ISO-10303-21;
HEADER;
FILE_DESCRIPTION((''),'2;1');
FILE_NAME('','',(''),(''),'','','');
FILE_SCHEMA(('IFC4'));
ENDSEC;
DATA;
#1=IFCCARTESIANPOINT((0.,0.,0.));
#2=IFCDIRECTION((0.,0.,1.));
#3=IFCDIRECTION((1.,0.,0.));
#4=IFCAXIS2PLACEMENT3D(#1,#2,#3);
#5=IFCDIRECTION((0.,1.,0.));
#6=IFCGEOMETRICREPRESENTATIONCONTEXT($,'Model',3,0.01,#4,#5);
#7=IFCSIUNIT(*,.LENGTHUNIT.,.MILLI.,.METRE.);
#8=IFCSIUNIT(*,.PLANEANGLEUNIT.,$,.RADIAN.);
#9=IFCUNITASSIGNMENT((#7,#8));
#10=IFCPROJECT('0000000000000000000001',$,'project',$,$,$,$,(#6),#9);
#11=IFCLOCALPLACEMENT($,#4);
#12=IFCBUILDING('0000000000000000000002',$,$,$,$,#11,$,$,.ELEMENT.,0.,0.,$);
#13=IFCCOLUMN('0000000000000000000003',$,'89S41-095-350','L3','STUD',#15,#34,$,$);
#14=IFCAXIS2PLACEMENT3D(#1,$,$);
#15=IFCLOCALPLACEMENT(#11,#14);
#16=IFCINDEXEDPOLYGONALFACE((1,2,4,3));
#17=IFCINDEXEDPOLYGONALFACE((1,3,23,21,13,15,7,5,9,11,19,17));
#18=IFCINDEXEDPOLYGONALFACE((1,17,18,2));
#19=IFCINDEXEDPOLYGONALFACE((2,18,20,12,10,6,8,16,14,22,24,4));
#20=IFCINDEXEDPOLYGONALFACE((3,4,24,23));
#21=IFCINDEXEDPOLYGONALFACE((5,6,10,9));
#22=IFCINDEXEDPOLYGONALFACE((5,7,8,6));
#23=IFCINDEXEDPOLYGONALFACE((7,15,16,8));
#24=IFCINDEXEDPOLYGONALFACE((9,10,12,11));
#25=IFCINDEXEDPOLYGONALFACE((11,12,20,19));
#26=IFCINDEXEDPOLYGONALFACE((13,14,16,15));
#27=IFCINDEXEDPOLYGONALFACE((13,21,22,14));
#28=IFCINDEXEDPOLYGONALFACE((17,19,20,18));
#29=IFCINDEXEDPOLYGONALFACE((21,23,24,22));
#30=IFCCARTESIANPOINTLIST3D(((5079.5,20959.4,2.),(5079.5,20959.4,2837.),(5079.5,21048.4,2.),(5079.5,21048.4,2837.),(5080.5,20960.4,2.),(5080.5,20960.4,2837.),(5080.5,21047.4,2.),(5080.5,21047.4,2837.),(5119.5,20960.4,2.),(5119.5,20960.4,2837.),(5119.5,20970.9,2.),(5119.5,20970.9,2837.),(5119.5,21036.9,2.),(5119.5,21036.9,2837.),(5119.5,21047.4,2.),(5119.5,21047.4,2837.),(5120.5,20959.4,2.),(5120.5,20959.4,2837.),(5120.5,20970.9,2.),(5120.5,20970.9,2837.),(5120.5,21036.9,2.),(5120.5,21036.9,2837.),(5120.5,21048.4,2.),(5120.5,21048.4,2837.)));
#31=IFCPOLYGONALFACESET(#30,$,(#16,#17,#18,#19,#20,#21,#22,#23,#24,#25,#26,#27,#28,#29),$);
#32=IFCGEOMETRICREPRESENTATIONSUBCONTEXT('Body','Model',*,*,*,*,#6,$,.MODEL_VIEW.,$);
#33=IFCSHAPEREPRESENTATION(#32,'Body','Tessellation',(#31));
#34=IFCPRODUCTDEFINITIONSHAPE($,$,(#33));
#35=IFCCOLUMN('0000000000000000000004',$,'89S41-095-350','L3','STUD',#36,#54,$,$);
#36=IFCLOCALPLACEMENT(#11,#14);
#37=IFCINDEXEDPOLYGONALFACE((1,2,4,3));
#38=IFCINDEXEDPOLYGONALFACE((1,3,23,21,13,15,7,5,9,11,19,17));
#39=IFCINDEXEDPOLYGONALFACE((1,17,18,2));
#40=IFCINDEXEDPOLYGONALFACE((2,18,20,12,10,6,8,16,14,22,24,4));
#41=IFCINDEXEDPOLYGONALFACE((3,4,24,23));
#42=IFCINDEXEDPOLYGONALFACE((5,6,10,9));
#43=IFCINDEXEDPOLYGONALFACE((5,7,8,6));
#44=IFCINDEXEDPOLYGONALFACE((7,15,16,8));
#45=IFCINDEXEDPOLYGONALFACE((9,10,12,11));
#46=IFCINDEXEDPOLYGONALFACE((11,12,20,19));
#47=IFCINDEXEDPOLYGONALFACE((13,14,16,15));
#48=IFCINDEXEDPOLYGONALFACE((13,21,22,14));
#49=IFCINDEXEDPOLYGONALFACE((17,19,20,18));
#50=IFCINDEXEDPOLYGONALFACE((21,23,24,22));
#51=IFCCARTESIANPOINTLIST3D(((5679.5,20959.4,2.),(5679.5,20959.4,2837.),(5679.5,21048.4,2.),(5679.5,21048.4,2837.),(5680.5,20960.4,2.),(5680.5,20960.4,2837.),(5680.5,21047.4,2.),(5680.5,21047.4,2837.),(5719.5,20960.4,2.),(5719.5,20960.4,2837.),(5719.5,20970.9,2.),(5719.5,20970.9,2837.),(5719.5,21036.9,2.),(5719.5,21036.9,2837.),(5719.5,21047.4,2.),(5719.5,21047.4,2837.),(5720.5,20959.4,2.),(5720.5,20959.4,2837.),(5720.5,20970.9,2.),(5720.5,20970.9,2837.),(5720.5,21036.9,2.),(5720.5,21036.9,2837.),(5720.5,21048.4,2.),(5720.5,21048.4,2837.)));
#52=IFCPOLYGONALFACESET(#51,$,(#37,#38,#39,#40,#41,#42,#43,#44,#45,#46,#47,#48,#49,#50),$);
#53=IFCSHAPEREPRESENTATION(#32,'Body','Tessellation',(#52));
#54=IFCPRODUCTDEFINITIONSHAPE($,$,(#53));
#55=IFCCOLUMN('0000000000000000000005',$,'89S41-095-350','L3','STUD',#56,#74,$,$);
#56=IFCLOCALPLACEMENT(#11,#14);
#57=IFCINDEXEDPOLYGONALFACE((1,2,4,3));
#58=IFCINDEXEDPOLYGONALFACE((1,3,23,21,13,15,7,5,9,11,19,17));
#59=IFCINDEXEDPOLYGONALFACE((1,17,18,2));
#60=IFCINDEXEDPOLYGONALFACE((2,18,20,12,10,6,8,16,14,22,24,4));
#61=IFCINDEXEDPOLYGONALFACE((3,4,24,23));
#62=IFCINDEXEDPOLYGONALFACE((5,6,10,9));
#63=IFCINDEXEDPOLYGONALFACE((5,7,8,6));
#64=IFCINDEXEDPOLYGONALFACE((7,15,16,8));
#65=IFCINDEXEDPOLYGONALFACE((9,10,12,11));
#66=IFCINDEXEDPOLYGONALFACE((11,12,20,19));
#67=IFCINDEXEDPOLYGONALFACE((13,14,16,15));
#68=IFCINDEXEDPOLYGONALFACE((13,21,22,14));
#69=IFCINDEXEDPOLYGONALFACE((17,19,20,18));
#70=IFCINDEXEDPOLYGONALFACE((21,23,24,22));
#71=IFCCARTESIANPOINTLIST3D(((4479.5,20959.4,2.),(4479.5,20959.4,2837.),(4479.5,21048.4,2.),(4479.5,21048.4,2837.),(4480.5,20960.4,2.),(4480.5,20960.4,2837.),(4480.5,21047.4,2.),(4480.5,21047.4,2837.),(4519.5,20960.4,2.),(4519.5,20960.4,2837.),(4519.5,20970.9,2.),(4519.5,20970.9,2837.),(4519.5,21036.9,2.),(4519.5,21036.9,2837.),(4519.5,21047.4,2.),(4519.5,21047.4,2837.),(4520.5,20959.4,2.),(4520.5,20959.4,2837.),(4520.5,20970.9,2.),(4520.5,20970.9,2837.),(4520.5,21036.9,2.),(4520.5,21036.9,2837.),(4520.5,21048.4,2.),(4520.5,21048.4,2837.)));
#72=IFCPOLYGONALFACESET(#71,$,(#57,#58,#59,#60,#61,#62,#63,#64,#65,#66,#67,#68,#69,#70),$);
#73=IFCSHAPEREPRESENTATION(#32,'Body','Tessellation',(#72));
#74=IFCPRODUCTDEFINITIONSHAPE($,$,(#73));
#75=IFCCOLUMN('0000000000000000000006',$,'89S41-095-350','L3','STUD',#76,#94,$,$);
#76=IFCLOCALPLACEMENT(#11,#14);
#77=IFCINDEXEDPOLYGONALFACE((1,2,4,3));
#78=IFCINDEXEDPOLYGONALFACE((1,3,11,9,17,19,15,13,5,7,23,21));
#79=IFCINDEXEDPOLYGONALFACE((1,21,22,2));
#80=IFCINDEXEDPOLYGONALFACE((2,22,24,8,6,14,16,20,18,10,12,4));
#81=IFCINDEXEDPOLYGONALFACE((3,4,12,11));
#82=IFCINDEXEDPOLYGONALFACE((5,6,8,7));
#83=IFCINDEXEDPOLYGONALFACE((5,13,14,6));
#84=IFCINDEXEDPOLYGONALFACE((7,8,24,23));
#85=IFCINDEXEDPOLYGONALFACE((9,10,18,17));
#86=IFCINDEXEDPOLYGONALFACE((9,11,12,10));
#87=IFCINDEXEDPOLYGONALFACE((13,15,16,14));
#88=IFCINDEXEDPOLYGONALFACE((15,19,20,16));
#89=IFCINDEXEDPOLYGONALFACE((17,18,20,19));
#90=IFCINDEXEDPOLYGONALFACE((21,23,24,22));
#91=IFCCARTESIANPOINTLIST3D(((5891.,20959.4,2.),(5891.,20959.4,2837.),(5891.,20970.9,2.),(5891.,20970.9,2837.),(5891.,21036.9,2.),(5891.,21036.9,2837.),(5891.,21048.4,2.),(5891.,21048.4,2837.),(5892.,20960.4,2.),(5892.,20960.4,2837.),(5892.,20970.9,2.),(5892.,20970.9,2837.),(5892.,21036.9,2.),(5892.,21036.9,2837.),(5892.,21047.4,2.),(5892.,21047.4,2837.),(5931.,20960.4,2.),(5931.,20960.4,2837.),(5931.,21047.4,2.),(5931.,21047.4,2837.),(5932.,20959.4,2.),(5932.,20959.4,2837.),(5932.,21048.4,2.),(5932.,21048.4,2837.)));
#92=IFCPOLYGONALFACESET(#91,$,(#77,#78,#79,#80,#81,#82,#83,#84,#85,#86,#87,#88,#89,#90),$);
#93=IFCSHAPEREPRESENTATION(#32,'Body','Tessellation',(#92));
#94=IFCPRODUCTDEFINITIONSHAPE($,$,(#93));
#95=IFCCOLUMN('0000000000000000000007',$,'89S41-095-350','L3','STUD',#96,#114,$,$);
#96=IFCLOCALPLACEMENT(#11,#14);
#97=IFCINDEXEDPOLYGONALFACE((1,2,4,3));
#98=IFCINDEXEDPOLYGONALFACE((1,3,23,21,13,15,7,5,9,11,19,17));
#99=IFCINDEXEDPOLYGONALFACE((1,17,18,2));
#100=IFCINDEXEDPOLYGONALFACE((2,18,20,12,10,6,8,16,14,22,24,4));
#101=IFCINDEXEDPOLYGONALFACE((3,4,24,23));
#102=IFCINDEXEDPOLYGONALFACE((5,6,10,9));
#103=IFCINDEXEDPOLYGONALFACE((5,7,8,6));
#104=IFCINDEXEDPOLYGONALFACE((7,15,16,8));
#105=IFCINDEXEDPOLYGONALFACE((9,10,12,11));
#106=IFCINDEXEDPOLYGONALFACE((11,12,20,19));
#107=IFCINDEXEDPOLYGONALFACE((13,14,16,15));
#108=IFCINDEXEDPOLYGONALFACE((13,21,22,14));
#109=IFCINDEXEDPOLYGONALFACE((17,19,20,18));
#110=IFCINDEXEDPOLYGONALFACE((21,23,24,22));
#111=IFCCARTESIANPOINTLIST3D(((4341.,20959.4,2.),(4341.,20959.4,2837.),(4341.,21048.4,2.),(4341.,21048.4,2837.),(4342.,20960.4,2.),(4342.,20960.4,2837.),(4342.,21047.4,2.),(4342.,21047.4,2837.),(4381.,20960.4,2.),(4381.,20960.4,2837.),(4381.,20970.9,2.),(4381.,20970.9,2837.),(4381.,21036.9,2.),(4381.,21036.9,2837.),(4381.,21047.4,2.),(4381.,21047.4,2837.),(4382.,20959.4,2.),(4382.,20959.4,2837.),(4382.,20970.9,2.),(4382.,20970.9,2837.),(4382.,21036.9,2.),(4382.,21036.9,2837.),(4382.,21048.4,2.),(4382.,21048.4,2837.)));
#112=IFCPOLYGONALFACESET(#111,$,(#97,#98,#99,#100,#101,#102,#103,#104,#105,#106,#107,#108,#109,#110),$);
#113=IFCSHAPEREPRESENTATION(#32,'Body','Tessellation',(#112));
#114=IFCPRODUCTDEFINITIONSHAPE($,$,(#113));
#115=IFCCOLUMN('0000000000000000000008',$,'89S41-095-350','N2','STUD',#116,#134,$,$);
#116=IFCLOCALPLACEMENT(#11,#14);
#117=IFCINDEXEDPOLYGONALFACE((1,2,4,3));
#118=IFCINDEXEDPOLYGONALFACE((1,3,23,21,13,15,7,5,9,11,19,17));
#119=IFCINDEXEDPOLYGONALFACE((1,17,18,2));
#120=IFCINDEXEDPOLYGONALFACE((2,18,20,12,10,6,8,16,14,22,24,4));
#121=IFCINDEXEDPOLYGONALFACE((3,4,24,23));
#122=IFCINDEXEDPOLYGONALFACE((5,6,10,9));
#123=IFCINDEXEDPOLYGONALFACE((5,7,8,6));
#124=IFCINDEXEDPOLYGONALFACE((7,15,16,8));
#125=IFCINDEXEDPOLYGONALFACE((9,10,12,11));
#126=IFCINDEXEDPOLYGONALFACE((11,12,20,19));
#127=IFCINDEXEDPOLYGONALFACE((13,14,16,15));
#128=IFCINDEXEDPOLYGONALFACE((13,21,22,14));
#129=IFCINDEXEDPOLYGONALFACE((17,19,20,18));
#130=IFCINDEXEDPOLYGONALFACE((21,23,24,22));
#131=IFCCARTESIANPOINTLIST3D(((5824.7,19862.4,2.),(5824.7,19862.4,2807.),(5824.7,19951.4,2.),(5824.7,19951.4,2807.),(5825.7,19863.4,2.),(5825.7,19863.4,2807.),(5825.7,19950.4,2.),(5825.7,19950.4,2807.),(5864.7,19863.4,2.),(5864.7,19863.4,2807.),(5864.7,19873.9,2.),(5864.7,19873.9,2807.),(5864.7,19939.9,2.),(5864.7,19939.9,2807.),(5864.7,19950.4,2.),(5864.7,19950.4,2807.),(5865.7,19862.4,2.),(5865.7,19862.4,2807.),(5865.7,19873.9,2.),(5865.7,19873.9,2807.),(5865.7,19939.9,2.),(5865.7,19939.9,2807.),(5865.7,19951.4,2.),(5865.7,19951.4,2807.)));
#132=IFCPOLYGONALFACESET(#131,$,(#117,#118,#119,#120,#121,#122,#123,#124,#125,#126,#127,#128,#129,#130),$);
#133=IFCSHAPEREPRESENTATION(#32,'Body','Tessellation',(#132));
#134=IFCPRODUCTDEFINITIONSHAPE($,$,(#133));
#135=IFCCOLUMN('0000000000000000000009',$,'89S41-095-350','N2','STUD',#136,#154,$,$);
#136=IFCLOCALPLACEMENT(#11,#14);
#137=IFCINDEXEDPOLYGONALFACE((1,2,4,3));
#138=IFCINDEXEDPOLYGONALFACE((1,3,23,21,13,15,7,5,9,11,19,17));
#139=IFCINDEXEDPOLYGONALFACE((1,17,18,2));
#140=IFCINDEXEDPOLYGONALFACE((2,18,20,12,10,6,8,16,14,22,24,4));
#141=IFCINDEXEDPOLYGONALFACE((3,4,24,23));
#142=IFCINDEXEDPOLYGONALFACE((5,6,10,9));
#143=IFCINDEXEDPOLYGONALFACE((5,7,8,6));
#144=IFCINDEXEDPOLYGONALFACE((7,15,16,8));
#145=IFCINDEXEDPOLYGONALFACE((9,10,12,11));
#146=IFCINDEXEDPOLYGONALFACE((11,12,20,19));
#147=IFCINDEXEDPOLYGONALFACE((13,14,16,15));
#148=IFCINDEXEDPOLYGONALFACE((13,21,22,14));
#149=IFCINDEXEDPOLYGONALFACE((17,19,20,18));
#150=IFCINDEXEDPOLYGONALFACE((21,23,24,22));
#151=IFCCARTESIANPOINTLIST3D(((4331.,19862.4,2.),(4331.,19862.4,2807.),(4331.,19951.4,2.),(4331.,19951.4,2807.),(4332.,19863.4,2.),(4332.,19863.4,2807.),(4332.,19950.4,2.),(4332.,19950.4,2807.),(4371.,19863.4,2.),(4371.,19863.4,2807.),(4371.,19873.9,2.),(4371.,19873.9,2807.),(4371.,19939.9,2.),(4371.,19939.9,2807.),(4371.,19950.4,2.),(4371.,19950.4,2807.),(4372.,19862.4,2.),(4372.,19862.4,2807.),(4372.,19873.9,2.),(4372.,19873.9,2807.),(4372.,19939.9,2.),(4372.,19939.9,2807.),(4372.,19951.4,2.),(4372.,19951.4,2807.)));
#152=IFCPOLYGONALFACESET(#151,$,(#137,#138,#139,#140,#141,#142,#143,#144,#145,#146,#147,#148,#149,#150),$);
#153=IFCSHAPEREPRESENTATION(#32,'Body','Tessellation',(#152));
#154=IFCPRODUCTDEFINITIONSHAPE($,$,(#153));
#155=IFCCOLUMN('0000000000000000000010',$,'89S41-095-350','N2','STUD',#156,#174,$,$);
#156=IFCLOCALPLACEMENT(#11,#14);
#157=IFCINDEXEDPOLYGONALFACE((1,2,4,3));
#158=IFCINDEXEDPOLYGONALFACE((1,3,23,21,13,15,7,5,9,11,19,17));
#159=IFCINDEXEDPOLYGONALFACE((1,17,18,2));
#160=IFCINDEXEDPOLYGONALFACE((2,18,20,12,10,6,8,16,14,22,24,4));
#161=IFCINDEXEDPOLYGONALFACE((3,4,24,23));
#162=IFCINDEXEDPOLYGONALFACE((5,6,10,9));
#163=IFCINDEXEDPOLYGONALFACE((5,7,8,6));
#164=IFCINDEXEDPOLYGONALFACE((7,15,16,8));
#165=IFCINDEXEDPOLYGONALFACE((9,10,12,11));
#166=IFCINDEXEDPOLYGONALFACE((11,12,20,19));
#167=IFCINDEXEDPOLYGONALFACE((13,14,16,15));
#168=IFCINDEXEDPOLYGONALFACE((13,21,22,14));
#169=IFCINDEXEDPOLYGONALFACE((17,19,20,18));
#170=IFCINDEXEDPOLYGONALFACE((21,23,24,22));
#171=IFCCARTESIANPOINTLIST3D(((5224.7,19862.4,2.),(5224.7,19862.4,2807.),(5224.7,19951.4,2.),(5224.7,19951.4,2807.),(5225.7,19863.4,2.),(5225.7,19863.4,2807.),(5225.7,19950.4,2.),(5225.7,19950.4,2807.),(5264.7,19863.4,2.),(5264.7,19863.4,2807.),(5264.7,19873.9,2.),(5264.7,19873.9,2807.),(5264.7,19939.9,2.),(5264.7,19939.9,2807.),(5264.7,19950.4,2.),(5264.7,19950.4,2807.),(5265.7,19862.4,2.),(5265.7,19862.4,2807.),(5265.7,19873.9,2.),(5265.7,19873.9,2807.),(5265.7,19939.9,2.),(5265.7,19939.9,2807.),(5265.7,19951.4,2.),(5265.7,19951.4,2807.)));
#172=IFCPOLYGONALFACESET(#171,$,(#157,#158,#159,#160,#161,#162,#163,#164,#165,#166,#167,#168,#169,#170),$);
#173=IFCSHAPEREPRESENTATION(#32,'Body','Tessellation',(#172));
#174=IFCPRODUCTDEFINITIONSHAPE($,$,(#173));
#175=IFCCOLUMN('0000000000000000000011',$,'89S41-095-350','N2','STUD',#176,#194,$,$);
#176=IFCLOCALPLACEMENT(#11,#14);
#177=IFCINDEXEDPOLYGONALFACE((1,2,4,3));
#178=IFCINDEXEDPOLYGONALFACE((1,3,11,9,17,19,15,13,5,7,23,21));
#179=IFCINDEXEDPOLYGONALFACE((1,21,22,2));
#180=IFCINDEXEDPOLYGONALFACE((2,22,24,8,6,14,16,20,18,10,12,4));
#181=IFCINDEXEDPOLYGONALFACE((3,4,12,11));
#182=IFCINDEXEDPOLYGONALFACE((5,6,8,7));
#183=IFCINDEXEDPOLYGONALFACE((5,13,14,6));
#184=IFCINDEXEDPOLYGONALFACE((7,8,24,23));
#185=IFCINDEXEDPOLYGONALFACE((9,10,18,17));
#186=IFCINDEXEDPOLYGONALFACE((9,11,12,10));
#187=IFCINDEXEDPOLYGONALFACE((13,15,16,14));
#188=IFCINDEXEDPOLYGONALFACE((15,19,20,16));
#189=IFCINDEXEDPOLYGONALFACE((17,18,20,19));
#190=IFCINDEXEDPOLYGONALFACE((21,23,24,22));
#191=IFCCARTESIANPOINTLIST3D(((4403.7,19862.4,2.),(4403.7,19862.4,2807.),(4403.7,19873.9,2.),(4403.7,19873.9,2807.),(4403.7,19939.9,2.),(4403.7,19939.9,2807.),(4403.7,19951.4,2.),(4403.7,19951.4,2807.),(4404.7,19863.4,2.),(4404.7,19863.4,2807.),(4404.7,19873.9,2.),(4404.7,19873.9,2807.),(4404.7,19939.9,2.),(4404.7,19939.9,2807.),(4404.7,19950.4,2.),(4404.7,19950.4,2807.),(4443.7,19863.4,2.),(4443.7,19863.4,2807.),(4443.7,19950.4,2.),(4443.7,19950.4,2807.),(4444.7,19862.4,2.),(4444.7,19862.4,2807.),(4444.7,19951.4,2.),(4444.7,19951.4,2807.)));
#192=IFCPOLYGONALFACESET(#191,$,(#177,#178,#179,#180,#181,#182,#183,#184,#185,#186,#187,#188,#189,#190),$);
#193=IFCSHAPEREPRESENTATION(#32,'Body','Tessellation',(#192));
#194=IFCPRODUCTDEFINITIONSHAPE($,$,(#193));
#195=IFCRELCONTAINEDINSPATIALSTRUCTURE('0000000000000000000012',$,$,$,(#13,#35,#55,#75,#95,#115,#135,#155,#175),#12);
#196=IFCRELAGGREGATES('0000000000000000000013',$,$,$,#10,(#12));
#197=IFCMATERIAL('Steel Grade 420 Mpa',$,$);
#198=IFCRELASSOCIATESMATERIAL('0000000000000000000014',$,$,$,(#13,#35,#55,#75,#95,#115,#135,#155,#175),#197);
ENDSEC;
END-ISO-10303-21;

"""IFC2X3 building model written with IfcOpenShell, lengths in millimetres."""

from ifc_helpers import new_model, si_unit, direction, frame, origin, origin_with_axes, origin_2d_with_axis, place, context, subcontext, project, spatial, c_section, extrude, source, transform, mapped, material, element, save


model = new_model("IFC2X3")

# Units and contexts
model_context = context("Model", 3, precision=0.01, world=origin_with_axes(), true_north=direction((0.0, 1.0, 0.0)))
body_context = subcontext(model_context, "Body", "Model", "MODEL_VIEW")
ifc_project = project(units=[si_unit("LENGTHUNIT", "METRE", prefix="MILLI"), si_unit("PLANEANGLEUNIT", "RADIAN")], contexts=[model_context])

# Building
building_placement = place(None, origin_with_axes())
building = spatial("IfcBuilding", under=ifc_project, at=building_placement, CompositionType="ELEMENT", ElevationOfRefHeight=0.0, ElevationOfTerrain=0.0)

# Columns
ifc_material = material(Name="Steel Grade 420 Mpa")
shared_shape_1 = source(origin(), body_context, "Body", "SweptSolid", [
    extrude(c_section(Depth=89.0, Width=41.0, WallThickness=1.0, Girth=11.5, at=origin_2d_with_axis()), origin_with_axes(), (0.0, 0.0, 1.0), 2835.0),
])
column_1_placement = place(None, frame((5100.0, 21003.9, 2.0), z_axis=(0.0, 0.0, 1.0), x_axis=(1.0, 0.0, 0.0)))
element("IfcColumn", 1, at=column_1_placement, inside=building, material=ifc_material, Name="89S41-095-350", Description="L3", ObjectType="STUD", context=body_context, shape_type="MappedRepresentation", body=[
    mapped(shared_shape_1, transform((0.0, 0.0, 0.0), scale=1.0)),
])
shared_shape_2 = source(origin(), body_context, "Body", "SweptSolid", [
    extrude(c_section(Depth=89.0, Width=41.0, WallThickness=1.0, Girth=11.5, at=origin_2d_with_axis()), origin_with_axes(), (0.0, 0.0, 1.0), 2835.0),
])
column_2_placement = place(None, frame((5700.0, 21003.9, 2.0), z_axis=(0.0, 0.0, 1.0), x_axis=(1.0, 0.0, 0.0)))
element("IfcColumn", 2, at=column_2_placement, inside=building, material=ifc_material, Name="89S41-095-350", Description="L3", ObjectType="STUD", context=body_context, shape_type="MappedRepresentation", body=[
    mapped(shared_shape_2, transform((0.0, 0.0, 0.0), scale=1.0)),
])
shared_shape_3 = source(origin(), body_context, "Body", "SweptSolid", [
    extrude(c_section(Depth=89.0, Width=41.0, WallThickness=1.0, Girth=11.5, at=origin_2d_with_axis()), origin_with_axes(), (0.0, 0.0, 1.0), 2835.0),
])
column_3_placement = place(None, frame((4500.0, 21003.9, 2.0), z_axis=(0.0, 0.0, 1.0), x_axis=(1.0, 0.0, 0.0)))
element("IfcColumn", 3, at=column_3_placement, inside=building, material=ifc_material, Name="89S41-095-350", Description="L3", ObjectType="STUD", context=body_context, shape_type="MappedRepresentation", body=[
    mapped(shared_shape_3, transform((0.0, 0.0, 0.0), scale=1.0)),
])
shared_shape_4 = source(origin(), body_context, "Body", "SweptSolid", [
    extrude(c_section(Depth=89.0, Width=41.0, WallThickness=1.0, Girth=11.5, at=origin_2d_with_axis()), origin_with_axes(), (0.0, 0.0, 1.0), 2835.0),
])
column_4_placement = place(None, frame((5911.5, 21003.9, 2.0), z_axis=(0.0, 0.0, 1.0), x_axis=(-1.0, 0.0, 0.0)))
element("IfcColumn", 4, at=column_4_placement, inside=building, material=ifc_material, Name="89S41-095-350", Description="L3", ObjectType="STUD", context=body_context, shape_type="MappedRepresentation", body=[
    mapped(shared_shape_4, transform((0.0, 0.0, 0.0), scale=1.0)),
])
shared_shape_5 = source(origin(), body_context, "Body", "SweptSolid", [
    extrude(c_section(Depth=89.0, Width=41.0, WallThickness=1.0, Girth=11.5, at=origin_2d_with_axis()), origin_with_axes(), (0.0, 0.0, 1.0), 2835.0),
])
column_5_placement = place(None, frame((4361.5, 21003.9, 2.0), z_axis=(0.0, 0.0, 1.0), x_axis=(1.0, 0.0, 0.0)))
element("IfcColumn", 5, at=column_5_placement, inside=building, material=ifc_material, Name="89S41-095-350", Description="L3", ObjectType="STUD", context=body_context, shape_type="MappedRepresentation", body=[
    mapped(shared_shape_5, transform((0.0, 0.0, 0.0), scale=1.0)),
])
shared_shape_6 = source(origin(), body_context, "Body", "SweptSolid", [
    extrude(c_section(Depth=89.0, Width=41.0, WallThickness=1.0, Girth=11.5, at=origin_2d_with_axis()), origin_with_axes(), (0.0, 0.0, 1.0), 2805.0),
])
column_6_placement = place(None, frame((5845.2, 19906.9, 2.0), z_axis=(0.0, 0.0, 1.0), x_axis=(1.0, 0.0, 0.0)))
element("IfcColumn", 6, at=column_6_placement, inside=building, material=ifc_material, Name="89S41-095-350", Description="N2", ObjectType="STUD", context=body_context, shape_type="MappedRepresentation", body=[
    mapped(shared_shape_6, transform((0.0, 0.0, 0.0), scale=1.0)),
])
shared_shape_7 = source(origin(), body_context, "Body", "SweptSolid", [
    extrude(c_section(Depth=89.0, Width=41.0, WallThickness=1.0, Girth=11.5, at=origin_2d_with_axis()), origin_with_axes(), (0.0, 0.0, 1.0), 2805.0),
])
column_7_placement = place(None, frame((4351.5, 19906.9, 2.0), z_axis=(0.0, 0.0, 1.0), x_axis=(1.0, 0.0, 0.0)))
element("IfcColumn", 7, at=column_7_placement, inside=building, material=ifc_material, Name="89S41-095-350", Description="N2", ObjectType="STUD", context=body_context, shape_type="MappedRepresentation", body=[
    mapped(shared_shape_7, transform((0.0, 0.0, 0.0), scale=1.0)),
])
shared_shape_8 = source(origin(), body_context, "Body", "SweptSolid", [
    extrude(c_section(Depth=89.0, Width=41.0, WallThickness=1.0, Girth=11.5, at=origin_2d_with_axis()), origin_with_axes(), (0.0, 0.0, 1.0), 2805.0),
])
column_8_placement = place(None, frame((5245.2, 19906.9, 2.0), z_axis=(0.0, 0.0, 1.0), x_axis=(1.0, 0.0, 0.0)))
element("IfcColumn", 8, at=column_8_placement, inside=building, material=ifc_material, Name="89S41-095-350", Description="N2", ObjectType="STUD", context=body_context, shape_type="MappedRepresentation", body=[
    mapped(shared_shape_8, transform((0.0, 0.0, 0.0), scale=1.0)),
])
shared_shape_9 = source(origin(), body_context, "Body", "SweptSolid", [
    extrude(c_section(Depth=89.0, Width=41.0, WallThickness=1.0, Girth=11.5, at=origin_2d_with_axis()), origin_with_axes(), (0.0, 0.0, 1.0), 2805.0),
])
column_9_placement = place(None, frame((4424.2, 19906.9, 2.0), z_axis=(0.0, 0.0, 1.0), x_axis=(-1.0, 0.0, 0.0)))
element("IfcColumn", 9, at=column_9_placement, inside=building, material=ifc_material, Name="89S41-095-350", Description="N2", ObjectType="STUD", context=body_context, shape_type="MappedRepresentation", body=[
    mapped(shared_shape_9, transform((0.0, 0.0, 0.0), scale=1.0)),
])

save(model, "model.ifc")
